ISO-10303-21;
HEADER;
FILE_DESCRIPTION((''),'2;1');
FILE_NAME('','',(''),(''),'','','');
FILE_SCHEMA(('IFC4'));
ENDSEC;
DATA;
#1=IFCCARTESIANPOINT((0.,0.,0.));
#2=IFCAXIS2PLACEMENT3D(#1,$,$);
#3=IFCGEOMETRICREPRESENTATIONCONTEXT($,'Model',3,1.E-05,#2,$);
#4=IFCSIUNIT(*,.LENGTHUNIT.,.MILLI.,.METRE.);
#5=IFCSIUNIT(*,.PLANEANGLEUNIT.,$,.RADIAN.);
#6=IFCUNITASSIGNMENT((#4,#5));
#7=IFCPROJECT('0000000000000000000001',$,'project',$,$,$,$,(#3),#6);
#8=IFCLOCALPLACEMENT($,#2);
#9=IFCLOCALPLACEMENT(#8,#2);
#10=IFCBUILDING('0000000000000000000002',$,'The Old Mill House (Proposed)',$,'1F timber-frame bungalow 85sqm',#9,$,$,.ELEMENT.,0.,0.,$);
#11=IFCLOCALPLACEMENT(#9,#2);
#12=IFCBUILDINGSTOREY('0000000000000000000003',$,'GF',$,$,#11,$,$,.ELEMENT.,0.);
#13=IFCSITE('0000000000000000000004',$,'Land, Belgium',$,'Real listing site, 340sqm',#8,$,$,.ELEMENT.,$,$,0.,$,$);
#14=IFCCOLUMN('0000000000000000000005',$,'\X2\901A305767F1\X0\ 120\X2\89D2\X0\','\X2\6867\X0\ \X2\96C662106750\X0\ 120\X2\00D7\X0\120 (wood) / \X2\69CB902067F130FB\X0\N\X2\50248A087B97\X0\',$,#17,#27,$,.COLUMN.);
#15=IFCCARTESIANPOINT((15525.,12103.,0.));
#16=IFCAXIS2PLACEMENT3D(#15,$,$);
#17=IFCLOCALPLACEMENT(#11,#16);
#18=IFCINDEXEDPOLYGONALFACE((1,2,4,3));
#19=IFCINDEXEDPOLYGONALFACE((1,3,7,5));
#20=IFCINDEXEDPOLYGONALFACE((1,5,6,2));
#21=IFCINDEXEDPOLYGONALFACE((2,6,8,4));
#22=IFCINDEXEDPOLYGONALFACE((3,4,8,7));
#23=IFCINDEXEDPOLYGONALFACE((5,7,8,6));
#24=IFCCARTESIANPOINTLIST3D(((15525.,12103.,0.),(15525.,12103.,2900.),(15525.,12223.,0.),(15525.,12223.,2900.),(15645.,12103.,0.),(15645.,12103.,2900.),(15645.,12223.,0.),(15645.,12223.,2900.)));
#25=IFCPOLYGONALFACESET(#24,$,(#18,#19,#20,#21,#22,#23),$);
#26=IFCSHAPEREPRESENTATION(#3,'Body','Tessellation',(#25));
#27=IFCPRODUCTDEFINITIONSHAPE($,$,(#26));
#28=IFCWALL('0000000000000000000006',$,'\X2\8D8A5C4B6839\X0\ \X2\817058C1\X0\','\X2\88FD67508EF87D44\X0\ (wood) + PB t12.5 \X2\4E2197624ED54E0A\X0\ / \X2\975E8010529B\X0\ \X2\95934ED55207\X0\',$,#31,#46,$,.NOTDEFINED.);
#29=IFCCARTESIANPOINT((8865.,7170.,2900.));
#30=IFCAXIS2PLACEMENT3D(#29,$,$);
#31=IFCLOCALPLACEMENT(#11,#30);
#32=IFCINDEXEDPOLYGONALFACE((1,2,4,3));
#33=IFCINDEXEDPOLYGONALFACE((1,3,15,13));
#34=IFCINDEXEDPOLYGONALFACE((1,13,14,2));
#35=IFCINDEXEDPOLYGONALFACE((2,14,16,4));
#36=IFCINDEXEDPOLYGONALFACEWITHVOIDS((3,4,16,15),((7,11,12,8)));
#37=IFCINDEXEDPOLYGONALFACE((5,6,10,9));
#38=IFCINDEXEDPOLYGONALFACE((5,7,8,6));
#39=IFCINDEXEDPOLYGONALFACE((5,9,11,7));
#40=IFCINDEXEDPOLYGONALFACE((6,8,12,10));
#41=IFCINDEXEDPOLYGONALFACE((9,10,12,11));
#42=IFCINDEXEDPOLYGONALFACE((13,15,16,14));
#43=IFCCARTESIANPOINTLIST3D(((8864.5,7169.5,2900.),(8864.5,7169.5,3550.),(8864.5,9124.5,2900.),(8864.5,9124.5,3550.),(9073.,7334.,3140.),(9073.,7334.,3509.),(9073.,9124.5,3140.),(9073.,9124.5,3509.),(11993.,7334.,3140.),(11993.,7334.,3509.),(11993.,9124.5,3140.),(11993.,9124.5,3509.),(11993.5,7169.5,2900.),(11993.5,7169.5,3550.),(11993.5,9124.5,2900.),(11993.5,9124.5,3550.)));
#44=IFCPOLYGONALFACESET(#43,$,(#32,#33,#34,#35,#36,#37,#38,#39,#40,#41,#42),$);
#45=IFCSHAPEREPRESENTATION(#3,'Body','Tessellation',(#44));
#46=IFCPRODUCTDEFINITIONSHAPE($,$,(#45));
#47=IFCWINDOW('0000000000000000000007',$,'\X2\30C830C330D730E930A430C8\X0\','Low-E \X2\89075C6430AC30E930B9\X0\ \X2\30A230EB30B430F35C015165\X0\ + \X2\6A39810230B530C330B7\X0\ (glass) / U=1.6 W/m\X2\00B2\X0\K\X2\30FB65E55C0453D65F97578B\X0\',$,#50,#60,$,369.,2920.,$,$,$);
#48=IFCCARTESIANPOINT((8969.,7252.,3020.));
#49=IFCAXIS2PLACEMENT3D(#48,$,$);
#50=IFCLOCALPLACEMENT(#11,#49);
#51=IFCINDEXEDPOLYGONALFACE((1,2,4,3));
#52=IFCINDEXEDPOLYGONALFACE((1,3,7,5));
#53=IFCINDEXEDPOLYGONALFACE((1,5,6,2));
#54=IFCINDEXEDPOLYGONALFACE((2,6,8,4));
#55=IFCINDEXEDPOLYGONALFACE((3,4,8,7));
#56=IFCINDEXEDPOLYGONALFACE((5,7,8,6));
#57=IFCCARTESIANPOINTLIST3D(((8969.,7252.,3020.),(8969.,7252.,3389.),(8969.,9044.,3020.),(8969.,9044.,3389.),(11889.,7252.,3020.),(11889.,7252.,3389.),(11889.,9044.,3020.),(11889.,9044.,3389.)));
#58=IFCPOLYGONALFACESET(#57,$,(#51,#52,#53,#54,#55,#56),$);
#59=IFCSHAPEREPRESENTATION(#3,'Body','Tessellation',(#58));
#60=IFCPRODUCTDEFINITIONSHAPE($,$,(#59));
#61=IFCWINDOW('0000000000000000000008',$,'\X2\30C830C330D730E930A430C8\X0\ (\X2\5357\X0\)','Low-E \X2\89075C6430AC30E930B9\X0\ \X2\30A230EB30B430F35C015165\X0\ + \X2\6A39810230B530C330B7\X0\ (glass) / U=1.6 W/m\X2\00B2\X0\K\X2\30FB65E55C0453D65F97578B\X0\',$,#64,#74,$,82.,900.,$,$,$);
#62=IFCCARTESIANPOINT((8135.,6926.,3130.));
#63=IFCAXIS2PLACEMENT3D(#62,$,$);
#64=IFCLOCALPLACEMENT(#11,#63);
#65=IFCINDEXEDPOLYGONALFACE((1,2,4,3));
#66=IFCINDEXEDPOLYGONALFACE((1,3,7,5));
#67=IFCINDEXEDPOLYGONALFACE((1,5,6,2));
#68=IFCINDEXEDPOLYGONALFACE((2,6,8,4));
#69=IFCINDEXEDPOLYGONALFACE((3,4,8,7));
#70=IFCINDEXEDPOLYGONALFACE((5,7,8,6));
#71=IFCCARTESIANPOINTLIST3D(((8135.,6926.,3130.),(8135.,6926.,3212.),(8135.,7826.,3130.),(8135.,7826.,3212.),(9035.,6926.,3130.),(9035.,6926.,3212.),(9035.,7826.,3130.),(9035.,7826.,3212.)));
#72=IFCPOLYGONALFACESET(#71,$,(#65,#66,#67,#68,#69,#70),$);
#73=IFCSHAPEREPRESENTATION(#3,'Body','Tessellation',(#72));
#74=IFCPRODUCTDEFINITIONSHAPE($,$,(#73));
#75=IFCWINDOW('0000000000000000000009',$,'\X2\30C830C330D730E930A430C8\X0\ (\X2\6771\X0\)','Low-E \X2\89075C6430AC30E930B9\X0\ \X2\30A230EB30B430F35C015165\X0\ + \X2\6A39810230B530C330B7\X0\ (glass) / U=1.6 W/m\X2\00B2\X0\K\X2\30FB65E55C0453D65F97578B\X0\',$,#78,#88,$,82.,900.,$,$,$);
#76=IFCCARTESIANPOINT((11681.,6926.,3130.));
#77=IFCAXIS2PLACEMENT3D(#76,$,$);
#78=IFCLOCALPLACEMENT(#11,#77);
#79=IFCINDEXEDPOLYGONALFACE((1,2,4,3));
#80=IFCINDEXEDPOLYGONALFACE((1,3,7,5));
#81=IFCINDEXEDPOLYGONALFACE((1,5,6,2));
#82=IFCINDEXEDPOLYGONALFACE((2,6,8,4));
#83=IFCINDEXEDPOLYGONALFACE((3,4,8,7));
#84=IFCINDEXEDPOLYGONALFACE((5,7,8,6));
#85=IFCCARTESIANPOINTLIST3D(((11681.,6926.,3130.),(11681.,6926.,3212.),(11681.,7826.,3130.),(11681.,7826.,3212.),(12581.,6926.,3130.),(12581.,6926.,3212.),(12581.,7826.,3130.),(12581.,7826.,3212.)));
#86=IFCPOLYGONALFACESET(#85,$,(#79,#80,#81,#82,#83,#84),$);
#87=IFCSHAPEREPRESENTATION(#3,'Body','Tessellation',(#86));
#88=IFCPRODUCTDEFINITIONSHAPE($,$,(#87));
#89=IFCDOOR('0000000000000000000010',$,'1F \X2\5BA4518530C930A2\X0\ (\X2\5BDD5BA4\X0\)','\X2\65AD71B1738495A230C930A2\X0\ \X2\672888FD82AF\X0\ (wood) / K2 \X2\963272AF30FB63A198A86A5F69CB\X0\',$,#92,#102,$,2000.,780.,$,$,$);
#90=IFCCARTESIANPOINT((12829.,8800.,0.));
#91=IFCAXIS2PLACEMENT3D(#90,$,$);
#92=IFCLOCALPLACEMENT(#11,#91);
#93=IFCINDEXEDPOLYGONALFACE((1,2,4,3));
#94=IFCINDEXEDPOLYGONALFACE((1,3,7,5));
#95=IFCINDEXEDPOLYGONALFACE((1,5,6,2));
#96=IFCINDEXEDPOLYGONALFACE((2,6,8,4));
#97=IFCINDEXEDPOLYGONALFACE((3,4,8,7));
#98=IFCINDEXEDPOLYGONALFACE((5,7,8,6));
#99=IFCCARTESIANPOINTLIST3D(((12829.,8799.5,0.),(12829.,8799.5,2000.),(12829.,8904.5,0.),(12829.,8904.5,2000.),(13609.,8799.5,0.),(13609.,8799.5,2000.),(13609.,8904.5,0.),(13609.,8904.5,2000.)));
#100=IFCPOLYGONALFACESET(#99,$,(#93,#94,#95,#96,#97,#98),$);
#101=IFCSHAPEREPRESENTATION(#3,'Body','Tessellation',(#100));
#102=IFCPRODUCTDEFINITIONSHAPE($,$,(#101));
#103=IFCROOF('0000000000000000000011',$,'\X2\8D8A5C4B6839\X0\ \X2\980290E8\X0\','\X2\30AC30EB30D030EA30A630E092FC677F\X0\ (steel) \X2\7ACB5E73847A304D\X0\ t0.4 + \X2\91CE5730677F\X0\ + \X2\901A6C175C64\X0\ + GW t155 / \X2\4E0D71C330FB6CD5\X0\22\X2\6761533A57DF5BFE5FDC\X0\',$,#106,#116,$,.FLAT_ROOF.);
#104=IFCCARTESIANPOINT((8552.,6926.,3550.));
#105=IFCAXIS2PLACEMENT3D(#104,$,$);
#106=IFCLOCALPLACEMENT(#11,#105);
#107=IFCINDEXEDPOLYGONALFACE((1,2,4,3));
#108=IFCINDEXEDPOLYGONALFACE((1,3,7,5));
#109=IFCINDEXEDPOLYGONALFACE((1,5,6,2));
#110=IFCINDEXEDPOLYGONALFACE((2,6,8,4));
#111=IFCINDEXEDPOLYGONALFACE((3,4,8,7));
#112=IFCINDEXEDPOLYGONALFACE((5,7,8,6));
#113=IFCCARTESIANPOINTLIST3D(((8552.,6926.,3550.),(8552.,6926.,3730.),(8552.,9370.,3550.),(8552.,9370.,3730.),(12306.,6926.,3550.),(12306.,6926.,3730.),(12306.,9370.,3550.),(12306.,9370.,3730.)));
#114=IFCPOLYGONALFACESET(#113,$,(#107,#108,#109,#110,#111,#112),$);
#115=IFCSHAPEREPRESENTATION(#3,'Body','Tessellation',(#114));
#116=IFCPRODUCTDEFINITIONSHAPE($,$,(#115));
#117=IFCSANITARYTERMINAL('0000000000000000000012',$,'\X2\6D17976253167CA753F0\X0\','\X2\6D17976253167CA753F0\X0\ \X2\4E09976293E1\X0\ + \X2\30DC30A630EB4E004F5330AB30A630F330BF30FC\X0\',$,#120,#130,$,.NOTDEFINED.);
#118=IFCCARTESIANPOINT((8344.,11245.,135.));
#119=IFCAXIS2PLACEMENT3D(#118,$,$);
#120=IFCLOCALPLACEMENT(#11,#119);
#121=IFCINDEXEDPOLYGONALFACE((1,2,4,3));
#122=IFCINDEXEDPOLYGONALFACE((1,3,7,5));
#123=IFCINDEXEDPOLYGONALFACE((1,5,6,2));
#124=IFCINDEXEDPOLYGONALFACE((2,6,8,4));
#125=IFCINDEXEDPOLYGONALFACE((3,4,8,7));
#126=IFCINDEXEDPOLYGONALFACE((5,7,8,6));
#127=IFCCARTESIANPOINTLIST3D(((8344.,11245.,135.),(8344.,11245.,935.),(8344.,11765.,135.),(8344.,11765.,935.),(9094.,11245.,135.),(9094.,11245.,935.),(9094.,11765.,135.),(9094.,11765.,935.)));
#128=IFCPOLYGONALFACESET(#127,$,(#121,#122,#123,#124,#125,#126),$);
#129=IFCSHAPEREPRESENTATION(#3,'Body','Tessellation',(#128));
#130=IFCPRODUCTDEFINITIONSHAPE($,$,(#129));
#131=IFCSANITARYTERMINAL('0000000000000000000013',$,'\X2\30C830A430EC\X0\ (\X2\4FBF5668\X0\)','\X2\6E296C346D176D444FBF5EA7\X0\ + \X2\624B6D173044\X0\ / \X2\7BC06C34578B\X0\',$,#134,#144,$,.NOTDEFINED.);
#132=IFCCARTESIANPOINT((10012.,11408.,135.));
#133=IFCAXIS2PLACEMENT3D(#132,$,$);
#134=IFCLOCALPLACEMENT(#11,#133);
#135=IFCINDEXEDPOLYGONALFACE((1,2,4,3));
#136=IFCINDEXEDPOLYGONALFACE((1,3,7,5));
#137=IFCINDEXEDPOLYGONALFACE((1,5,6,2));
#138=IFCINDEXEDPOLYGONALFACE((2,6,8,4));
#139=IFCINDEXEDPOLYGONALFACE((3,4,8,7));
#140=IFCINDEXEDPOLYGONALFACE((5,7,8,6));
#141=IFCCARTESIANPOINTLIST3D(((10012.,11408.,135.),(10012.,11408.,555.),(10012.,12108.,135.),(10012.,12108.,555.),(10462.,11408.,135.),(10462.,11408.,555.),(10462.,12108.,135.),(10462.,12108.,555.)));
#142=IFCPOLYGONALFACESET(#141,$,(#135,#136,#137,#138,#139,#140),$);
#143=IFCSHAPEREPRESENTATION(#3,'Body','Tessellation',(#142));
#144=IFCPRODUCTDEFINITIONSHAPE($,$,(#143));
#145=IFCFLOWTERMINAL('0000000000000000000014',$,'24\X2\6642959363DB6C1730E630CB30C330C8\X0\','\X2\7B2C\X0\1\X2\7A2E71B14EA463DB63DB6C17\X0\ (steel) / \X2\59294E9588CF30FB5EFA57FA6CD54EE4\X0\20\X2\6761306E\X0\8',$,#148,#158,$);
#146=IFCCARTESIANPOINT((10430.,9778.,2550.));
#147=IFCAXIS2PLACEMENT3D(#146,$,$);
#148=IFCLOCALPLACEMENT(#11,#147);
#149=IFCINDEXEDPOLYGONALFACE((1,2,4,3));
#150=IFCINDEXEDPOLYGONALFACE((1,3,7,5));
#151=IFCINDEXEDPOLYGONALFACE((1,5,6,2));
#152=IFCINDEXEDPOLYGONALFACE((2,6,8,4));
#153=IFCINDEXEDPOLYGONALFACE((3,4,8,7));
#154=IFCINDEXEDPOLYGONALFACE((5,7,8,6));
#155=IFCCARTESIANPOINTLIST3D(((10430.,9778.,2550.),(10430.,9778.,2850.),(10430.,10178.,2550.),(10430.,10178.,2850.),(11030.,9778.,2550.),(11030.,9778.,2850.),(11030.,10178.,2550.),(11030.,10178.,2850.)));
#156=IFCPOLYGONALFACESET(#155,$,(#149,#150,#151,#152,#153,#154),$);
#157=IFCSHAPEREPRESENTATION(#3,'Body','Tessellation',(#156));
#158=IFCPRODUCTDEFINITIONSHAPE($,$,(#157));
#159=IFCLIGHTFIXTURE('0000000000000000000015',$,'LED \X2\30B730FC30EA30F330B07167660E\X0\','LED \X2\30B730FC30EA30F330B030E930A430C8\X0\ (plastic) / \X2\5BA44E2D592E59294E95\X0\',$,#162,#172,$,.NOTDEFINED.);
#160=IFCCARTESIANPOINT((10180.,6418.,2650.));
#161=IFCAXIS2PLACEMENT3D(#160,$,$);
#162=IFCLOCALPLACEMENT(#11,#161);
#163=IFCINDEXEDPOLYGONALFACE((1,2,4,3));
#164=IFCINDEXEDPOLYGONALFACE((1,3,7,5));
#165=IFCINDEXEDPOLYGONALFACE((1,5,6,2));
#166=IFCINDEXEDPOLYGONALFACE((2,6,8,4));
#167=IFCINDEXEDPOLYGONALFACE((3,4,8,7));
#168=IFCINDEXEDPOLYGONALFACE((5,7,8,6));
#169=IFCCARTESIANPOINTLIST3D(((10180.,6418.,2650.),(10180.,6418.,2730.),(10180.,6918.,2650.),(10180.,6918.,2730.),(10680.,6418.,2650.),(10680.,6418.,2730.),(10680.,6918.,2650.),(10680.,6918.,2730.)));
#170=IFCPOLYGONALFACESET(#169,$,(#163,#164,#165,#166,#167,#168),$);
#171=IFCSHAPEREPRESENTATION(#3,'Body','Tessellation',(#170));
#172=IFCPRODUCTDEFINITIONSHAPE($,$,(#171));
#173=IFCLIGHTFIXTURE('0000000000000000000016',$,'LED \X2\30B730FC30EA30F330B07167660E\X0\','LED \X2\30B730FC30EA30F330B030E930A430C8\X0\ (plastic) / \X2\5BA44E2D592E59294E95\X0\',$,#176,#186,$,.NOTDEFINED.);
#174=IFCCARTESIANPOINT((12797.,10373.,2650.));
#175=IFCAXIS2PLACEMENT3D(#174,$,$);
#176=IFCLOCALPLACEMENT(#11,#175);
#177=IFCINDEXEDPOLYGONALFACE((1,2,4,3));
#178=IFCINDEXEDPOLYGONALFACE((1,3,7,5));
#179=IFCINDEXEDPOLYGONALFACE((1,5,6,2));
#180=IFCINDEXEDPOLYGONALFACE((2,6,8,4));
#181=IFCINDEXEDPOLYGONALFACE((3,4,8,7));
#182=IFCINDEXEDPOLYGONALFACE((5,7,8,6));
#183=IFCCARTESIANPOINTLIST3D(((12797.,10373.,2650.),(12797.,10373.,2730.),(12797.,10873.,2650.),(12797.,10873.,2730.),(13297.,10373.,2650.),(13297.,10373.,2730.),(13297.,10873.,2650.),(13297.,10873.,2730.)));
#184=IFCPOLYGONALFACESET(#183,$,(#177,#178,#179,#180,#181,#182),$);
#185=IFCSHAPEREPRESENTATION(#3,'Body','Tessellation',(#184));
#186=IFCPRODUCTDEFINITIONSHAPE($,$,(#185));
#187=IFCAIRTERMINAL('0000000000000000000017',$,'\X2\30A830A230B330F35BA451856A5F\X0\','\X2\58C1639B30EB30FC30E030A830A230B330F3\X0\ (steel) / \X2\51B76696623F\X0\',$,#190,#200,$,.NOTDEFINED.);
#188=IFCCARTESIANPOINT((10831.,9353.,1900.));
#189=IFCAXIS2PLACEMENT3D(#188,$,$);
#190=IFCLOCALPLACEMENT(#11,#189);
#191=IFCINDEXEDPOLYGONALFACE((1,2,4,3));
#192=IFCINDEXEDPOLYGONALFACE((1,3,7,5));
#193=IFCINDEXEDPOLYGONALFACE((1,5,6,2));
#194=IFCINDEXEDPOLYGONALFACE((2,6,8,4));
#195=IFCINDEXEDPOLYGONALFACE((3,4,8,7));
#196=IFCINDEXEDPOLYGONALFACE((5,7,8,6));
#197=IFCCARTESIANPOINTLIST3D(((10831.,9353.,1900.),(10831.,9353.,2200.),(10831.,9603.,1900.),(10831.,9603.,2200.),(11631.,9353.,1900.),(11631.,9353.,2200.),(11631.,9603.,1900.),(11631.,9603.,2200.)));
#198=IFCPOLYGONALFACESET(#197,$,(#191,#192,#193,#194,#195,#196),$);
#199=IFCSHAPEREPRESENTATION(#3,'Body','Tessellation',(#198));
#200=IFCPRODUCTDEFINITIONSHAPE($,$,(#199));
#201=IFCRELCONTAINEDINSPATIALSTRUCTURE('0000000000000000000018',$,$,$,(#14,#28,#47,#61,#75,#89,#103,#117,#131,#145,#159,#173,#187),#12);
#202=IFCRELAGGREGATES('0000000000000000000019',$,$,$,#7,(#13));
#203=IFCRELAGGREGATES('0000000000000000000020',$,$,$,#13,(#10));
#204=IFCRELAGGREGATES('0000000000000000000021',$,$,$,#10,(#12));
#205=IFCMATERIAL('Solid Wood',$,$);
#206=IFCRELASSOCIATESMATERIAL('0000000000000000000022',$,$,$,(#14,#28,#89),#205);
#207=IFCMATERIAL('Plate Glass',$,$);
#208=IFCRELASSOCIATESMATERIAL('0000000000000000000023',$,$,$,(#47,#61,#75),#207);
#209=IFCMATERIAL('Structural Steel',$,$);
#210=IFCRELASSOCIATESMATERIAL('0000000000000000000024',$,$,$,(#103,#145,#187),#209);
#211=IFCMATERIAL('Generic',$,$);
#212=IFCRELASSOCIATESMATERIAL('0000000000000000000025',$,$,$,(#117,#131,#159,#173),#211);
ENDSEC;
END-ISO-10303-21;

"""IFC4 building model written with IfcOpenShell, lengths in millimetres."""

from ifc_helpers import new_model, si_unit, frame, frame_2d, origin, place, context, project, spatial, rectangle, extrude, material, element, fill, save


model = new_model("IFC4")

# Units and contexts
model_context = context("Model", 3, precision=1e-05, world=origin())
ifc_project = project(units=[si_unit("LENGTHUNIT", "METRE", prefix="MILLI"), si_unit("PLANEANGLEUNIT", "RADIAN")], contexts=[model_context])

# Site, building, storey
site_placement = place(None, origin())
site = spatial("IfcSite", under=ifc_project, at=site_placement, Name="Land, Belgium", ObjectType="Real listing site, 340sqm", CompositionType="ELEMENT", RefElevation=0.0)
building_placement = place(site_placement, origin())
building = spatial("IfcBuilding", under=site, at=building_placement, Name="The Old Mill House (Proposed)", ObjectType="1F timber-frame bungalow 85sqm", CompositionType="ELEMENT", ElevationOfRefHeight=0.0, ElevationOfTerrain=0.0)
storey_placement = place(building_placement, origin())
storey = spatial("IfcBuildingStorey", under=building, at=storey_placement, Name="GF", CompositionType="ELEMENT", Elevation=0.0)

# Column
ifc_material_1 = material(Name="Solid Wood")
column_1_placement = place(storey_placement, frame((15525.0, 12103.0, 0.0)))
element("IfcColumn", 1, at=column_1_placement, inside=storey, material=ifc_material_1, Name="通し柱 120角", Description="桧 集成材 120×120 (wood) / 構造柱・N値計算", PredefinedType="COLUMN", context=model_context, shape_type="SweptSolid", body=[
    extrude(rectangle(XDim=120.0, YDim=120.0, at=frame_2d((60.0, 60.0))), frame((15525.0, 12103.0, 0.0)), (0.0, 0.0, 1.0), 2900.0),
])

# Wall, openings, windows
wall_1_placement = place(storey_placement, frame((8865.0, 7170.0, 2900.0)))
wall_1 = element("IfcWall", 2, at=wall_1_placement, inside=storey, material=ifc_material_1, Name="越屋根 腰壁", Description="製材軸組 (wood) + PB t12.5 両面仕上 / 非耐力 間仕切", PredefinedType="NOTDEFINED", context=model_context, shape_type="SweptSolid", body=[
    extrude(rectangle(XDim=3129.0, YDim=1955.0, at=frame_2d((1564.0, 977.0))), frame((8865.0, 7170.0, 2900.0)), (0.0, 0.0, 1.0), 650.0),
])
opening_1_placement = place(storey_placement, frame((8969.0, 7252.0, 3020.0)))
opening_1 = element("IfcOpeningElement", 3, at=opening_1_placement, cuts=wall_1, PredefinedType="NOTDEFINED", context=model_context, shape_type="SweptSolid", body=[
    extrude(rectangle(XDim=2920.0, YDim=1792.0, at=frame_2d((1460.0, 896.0))), frame((8969.0, 7252.0, 3020.0)), (0.0, 0.0, 1.0), 369.0),
])
opening_2_placement = place(storey_placement, frame((8135.0, 6926.0, 3130.0)))
opening_2 = element("IfcOpeningElement", 4, at=opening_2_placement, cuts=wall_1, PredefinedType="NOTDEFINED", context=model_context, shape_type="SweptSolid", body=[
    extrude(rectangle(XDim=900.0, YDim=900.0, at=frame_2d((450.0, 450.0))), frame((8135.0, 6926.0, 3130.0)), (0.0, 0.0, 1.0), 82.0),
])
opening_3_placement = place(storey_placement, frame((11681.0, 6926.0, 3130.0)))
opening_3 = element("IfcOpeningElement", 5, at=opening_3_placement, cuts=wall_1, PredefinedType="NOTDEFINED", context=model_context, shape_type="SweptSolid", body=[
    extrude(rectangle(XDim=900.0, YDim=900.0, at=frame_2d((450.0, 450.0))), frame((11681.0, 6926.0, 3130.0)), (0.0, 0.0, 1.0), 82.0),
])
ifc_material_2 = material(Name="Plate Glass")
window_1_placement = place(storey_placement, frame((8969.0, 7252.0, 3020.0)))
window_1 = element("IfcWindow", 6, at=window_1_placement, inside=storey, material=ifc_material_2, Name="トップライト", Description="Low-E 複層ガラス アルゴン封入 + 樹脂サッシ (glass) / U=1.6 W/m²K・日射取得型", OverallHeight=369.0, OverallWidth=2920.0, context=model_context, shape_type="SweptSolid", body=[
    extrude(rectangle(XDim=2920.0, YDim=1792.0, at=frame_2d((1460.0, 896.0))), frame((8969.0, 7252.0, 3020.0)), (0.0, 0.0, 1.0), 369.0),
])
fill(opening_1, window_1)
window_2_placement = place(storey_placement, frame((8135.0, 6926.0, 3130.0)))
window_2 = element("IfcWindow", 7, at=window_2_placement, inside=storey, material=ifc_material_2, Name="トップライト (南)", Description="Low-E 複層ガラス アルゴン封入 + 樹脂サッシ (glass) / U=1.6 W/m²K・日射取得型", OverallHeight=82.0, OverallWidth=900.0, context=model_context, shape_type="SweptSolid", body=[
    extrude(rectangle(XDim=900.0, YDim=900.0, at=frame_2d((450.0, 450.0))), frame((8135.0, 6926.0, 3130.0)), (0.0, 0.0, 1.0), 82.0),
])
fill(opening_2, window_2)
window_3_placement = place(storey_placement, frame((11681.0, 6926.0, 3130.0)))
window_3 = element("IfcWindow", 8, at=window_3_placement, inside=storey, material=ifc_material_2, Name="トップライト (東)", Description="Low-E 複層ガラス アルゴン封入 + 樹脂サッシ (glass) / U=1.6 W/m²K・日射取得型", OverallHeight=82.0, OverallWidth=900.0, context=model_context, shape_type="SweptSolid", body=[
    extrude(rectangle(XDim=900.0, YDim=900.0, at=frame_2d((450.0, 450.0))), frame((11681.0, 6926.0, 3130.0)), (0.0, 0.0, 1.0), 82.0),
])
fill(opening_3, window_3)

# Door
door_placement = place(storey_placement, frame((12829.0, 8800.0, 0.0)))
element("IfcDoor", 9, at=door_placement, inside=storey, material=ifc_material_1, Name="1F 室内ドア (寝室)", Description="断熱玄関ドア 木製芯 (wood) / K2 防犯・採風機構", OverallHeight=2000.0, OverallWidth=780.0, context=model_context, shape_type="SweptSolid", body=[
    extrude(rectangle(XDim=780.0, YDim=105.0, at=frame_2d((390.0, 52.0))), frame((12829.0, 8800.0, 0.0)), (0.0, 0.0, 1.0), 2000.0),
])

# Roof
ifc_material_3 = material(Name="Structural Steel")
roof_placement = place(storey_placement, frame((8552.0, 6926.0, 3550.0)))
element("IfcRoof", 10, at=roof_placement, inside=storey, material=ifc_material_3, Name="越屋根 頂部", Description="ガルバリウム鋼板 (steel) 立平葺き t0.4 + 野地板 + 通気層 + GW t155 / 不燃・法22条区域対応", PredefinedType="FLAT_ROOF", context=model_context, shape_type="SweptSolid", body=[
    extrude(rectangle(XDim=3754.0, YDim=2444.0, at=frame_2d((1877.0, 1222.0))), frame((8552.0, 6926.0, 3550.0)), (0.0, 0.0, 1.0), 180.0),
])

# Sanitary terminals
ifc_material_4 = material(Name="Generic")
sanitary_terminal_1_placement = place(storey_placement, frame((8344.0, 11245.0, 135.0)))
element("IfcSanitaryTerminal", 11, at=sanitary_terminal_1_placement, inside=storey, material=ifc_material_4, Name="洗面化粧台", Description="洗面化粧台 三面鏡 + ボウル一体カウンター", PredefinedType="NOTDEFINED", context=model_context, shape_type="SweptSolid", body=[
    extrude(rectangle(XDim=750.0, YDim=520.0, at=frame_2d((375.0, 260.0))), frame((8344.0, 11245.0, 135.0)), (0.0, 0.0, 1.0), 800.0),
])
sanitary_terminal_2_placement = place(storey_placement, frame((10012.0, 11408.0, 135.0)))
element("IfcSanitaryTerminal", 12, at=sanitary_terminal_2_placement, inside=storey, material=ifc_material_4, Name="トイレ (便器)", Description="温水洗浄便座 + 手洗い / 節水型", PredefinedType="NOTDEFINED", context=model_context, shape_type="SweptSolid", body=[
    extrude(rectangle(XDim=450.0, YDim=700.0, at=frame_2d((225.0, 350.0))), frame((10012.0, 11408.0, 135.0)), (0.0, 0.0, 1.0), 420.0),
])

# Flow terminal
flow_terminal_placement = place(storey_placement, frame((10430.0, 9778.0, 2550.0)))
element("IfcFlowTerminal", 13, at=flow_terminal_placement, inside=storey, material=ifc_material_3, Name="24時間換気ユニット", Description="第1種熱交換換気 (steel) / 天井裏・建基法令20条の8", context=model_context, shape_type="SweptSolid", body=[
    extrude(rectangle(XDim=600.0, YDim=400.0, at=frame_2d((300.0, 200.0))), frame((10430.0, 9778.0, 2550.0)), (0.0, 0.0, 1.0), 300.0),
])

# Light fixtures
light_fixture_1_placement = place(storey_placement, frame((10180.0, 6418.0, 2650.0)))
element("IfcLightFixture", 14, at=light_fixture_1_placement, inside=storey, material=ifc_material_4, Name="LED シーリング照明", Description="LED シーリングライト (plastic) / 室中央天井", PredefinedType="NOTDEFINED", context=model_context, shape_type="SweptSolid", body=[
    extrude(rectangle(XDim=500.0, YDim=500.0, at=frame_2d((250.0, 250.0))), frame((10180.0, 6418.0, 2650.0)), (0.0, 0.0, 1.0), 80.0),
])
light_fixture_2_placement = place(storey_placement, frame((12797.0, 10373.0, 2650.0)))
element("IfcLightFixture", 15, at=light_fixture_2_placement, inside=storey, material=ifc_material_4, Name="LED シーリング照明", Description="LED シーリングライト (plastic) / 室中央天井", PredefinedType="NOTDEFINED", context=model_context, shape_type="SweptSolid", body=[
    extrude(rectangle(XDim=500.0, YDim=500.0, at=frame_2d((250.0, 250.0))), frame((12797.0, 10373.0, 2650.0)), (0.0, 0.0, 1.0), 80.0),
])

# Air terminal
air_terminal_placement = place(storey_placement, frame((10831.0, 9353.0, 1900.0)))
element("IfcAirTerminal", 16, at=air_terminal_placement, inside=storey, material=ifc_material_3, Name="エアコン室内機", Description="壁掛ルームエアコン (steel) / 冷暖房", PredefinedType="NOTDEFINED", context=model_context, shape_type="SweptSolid", body=[
    extrude(rectangle(XDim=800.0, YDim=250.0, at=frame_2d((400.0, 125.0))), frame((10831.0, 9353.0, 1900.0)), (0.0, 0.0, 1.0), 300.0),
])

save(model, "model.ifc")
